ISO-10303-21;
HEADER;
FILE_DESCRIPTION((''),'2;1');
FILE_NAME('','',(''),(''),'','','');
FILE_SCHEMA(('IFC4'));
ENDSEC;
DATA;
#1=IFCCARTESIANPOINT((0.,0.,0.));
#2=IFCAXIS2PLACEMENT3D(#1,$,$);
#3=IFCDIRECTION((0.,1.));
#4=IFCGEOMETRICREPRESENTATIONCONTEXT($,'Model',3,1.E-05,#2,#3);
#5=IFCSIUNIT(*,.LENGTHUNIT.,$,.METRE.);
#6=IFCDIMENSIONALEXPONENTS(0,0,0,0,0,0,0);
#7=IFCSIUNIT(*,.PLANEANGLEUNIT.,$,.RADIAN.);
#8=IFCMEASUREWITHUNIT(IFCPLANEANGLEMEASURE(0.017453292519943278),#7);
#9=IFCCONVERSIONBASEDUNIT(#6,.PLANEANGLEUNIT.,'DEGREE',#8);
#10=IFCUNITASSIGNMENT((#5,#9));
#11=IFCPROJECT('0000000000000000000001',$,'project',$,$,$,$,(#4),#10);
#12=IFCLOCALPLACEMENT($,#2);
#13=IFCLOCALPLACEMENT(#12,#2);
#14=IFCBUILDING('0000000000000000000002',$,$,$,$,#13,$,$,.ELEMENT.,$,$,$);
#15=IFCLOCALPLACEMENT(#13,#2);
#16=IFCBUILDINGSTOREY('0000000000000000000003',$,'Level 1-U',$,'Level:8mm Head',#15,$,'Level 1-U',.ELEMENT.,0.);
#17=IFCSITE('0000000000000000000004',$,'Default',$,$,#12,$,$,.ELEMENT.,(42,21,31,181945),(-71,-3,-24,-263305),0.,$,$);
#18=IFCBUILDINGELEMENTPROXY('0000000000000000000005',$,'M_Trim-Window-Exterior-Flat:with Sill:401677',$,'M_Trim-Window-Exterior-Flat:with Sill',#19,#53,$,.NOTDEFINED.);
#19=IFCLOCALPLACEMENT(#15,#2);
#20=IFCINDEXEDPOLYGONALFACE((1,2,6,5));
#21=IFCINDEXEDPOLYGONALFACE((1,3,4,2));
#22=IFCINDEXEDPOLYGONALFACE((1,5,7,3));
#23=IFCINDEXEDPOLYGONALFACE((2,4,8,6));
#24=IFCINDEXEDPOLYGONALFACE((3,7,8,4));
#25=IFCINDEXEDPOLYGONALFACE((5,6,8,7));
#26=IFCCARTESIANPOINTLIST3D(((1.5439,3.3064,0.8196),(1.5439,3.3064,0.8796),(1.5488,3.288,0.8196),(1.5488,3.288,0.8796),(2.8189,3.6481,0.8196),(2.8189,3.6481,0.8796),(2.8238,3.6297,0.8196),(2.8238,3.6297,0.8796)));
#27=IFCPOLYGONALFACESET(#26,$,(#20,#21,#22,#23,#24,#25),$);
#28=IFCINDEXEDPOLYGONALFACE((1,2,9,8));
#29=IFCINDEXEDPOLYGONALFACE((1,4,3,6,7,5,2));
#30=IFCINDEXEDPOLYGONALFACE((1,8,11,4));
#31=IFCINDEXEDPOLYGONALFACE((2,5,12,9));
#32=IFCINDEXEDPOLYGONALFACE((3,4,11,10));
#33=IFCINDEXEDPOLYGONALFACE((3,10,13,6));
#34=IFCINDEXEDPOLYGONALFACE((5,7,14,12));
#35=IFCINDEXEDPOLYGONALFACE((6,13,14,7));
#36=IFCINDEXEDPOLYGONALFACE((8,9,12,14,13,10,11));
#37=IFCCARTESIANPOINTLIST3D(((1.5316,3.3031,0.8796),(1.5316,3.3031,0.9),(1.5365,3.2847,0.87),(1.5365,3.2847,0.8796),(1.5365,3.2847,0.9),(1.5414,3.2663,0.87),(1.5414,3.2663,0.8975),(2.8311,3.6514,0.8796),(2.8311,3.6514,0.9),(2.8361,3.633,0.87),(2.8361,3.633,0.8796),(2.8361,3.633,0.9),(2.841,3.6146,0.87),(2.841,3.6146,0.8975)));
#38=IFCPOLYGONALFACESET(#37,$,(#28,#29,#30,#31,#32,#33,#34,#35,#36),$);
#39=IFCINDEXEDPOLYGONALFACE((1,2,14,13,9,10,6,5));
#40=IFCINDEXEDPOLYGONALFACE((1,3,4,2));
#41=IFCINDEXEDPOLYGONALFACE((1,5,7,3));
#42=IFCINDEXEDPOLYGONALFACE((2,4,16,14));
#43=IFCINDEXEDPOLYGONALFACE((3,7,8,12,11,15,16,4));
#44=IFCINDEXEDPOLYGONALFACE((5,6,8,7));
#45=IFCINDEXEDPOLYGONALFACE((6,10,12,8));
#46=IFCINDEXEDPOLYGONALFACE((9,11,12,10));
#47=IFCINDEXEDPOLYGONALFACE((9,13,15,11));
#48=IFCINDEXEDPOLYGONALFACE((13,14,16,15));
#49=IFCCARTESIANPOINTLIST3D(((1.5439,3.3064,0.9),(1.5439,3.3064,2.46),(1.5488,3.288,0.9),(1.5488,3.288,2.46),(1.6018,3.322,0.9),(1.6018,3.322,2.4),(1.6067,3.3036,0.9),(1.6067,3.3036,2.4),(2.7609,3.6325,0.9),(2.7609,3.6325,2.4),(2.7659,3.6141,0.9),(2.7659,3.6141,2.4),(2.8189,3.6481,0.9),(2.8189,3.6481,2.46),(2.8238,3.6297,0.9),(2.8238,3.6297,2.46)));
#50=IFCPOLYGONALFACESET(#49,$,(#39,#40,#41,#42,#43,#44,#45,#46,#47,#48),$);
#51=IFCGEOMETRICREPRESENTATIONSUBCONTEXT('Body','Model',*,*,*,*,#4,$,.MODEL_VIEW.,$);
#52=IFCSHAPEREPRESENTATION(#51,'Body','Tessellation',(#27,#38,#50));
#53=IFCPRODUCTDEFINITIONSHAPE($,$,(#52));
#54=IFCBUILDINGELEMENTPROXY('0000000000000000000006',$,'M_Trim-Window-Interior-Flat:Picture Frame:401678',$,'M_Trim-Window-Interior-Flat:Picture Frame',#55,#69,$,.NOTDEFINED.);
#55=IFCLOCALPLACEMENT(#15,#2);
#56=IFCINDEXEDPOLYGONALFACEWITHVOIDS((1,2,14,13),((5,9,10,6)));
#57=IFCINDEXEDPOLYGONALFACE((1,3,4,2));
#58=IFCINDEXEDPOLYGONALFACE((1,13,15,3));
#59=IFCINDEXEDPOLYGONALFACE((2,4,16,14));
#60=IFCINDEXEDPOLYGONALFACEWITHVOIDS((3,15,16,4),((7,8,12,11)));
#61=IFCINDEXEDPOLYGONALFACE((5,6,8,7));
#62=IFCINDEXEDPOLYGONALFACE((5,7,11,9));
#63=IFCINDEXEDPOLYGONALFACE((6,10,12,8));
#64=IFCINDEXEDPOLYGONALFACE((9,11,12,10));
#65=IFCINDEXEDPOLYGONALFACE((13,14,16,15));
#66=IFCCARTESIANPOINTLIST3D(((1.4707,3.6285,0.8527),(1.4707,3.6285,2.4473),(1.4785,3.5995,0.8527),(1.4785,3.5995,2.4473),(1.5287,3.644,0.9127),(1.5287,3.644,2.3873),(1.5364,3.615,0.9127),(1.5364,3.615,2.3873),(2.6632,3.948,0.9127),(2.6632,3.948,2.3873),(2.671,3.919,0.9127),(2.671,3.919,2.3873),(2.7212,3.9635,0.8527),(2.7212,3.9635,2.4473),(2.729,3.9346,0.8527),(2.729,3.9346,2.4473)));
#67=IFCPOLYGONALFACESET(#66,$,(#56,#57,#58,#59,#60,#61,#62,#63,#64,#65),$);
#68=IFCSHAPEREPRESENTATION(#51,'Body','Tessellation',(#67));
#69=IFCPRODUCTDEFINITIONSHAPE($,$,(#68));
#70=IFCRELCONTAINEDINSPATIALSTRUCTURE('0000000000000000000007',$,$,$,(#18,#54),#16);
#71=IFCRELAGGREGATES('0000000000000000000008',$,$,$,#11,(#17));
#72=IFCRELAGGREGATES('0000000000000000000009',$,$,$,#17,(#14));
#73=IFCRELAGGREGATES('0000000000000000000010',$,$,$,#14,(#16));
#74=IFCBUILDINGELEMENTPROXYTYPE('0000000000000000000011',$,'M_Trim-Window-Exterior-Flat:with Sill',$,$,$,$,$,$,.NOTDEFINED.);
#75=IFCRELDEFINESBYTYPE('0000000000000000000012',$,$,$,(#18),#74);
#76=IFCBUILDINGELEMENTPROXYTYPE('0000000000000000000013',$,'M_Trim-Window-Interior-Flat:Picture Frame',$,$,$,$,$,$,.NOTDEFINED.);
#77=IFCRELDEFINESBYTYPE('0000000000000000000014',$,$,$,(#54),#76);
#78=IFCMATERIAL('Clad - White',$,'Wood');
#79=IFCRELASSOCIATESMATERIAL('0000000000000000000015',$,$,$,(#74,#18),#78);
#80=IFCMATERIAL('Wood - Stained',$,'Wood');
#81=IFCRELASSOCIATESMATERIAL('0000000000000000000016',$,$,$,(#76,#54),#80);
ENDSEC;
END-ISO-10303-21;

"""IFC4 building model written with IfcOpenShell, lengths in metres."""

from ifc_helpers import new_model, entity, si_unit, converted_unit, direction, frame, origin, place, context, subcontext, project, spatial, indexed_curve, outline, extrude, source, transform, mapped, material, type_object, type_shapes, element, save


model = new_model("IFC4")

# Units and contexts
model_context = context("Model", 3, precision=1e-05, world=origin(), true_north=direction((0.0, 1.0)))
body_context = subcontext(model_context, "Body", "Model", "MODEL_VIEW")
ifc_project = project(units=[si_unit("LENGTHUNIT", "METRE"), converted_unit("PLANEANGLEUNIT", "DEGREE", entity("IfcPlaneAngleMeasure", 0.017453292519943278), si_unit("PLANEANGLEUNIT", "RADIAN"), dimensions=[0, 0, 0, 0, 0, 0, 0])], contexts=[model_context])

# Site, building, storey
site_placement = place(None, origin())
site = spatial("IfcSite", under=ifc_project, at=site_placement, Name="Default", CompositionType="ELEMENT", RefLatitude=(42, 21, 31, 181945), RefLongitude=(-71, -3, -24, -263305), RefElevation=0.0)
building_placement = place(site_placement, origin())
building = spatial("IfcBuilding", under=site, at=building_placement, CompositionType="ELEMENT")
storey_placement = place(building_placement, origin())
storey = spatial("IfcBuildingStorey", under=building, at=storey_placement, Name="Level 1-U", ObjectType="Level:8mm Head", LongName="Level 1-U", CompositionType="ELEMENT", Elevation=0.0)

# Building element proxies
ifc_material_1 = material(Name="Clad - White", Category="Wood")
ifc_material_2 = material(Name="Wood - Stained", Category="Wood")
building_element_proxy_type_1 = type_object("IfcBuildingElementProxyType", Name="M_Trim-Window-Exterior-Flat:with Sill", PredefinedType="NOTDEFINED", material=ifc_material_1)
shared_shape_1 = source(origin(), body_context, "Body", "SweptSolid", [
    extrude(outline(indexed_curve([(-0.66, -0.03), (0.66, -0.03), (0.66, 0.03), (-0.66, 0.03), (-0.66, -0.03)], self_intersect=False)), frame((0.0, -1.5504, 0.0), z_axis=(0.0, 0.0, 1.0), x_axis=(-1.0, 0.0, 0.0)), (0.0, 0.0, 1.0), 0.019),
    extrude(outline(indexed_curve([(-0.019, -0.0152), (0.0, -0.0152), (0.0, -0.0057), (0.019, -0.0057), (0.019, 0.0148), (0.0, 0.0148), (-0.019, 0.0123), (-0.019, -0.0152)], self_intersect=False)), frame((-0.6727, -1.5148, 0.019), z_axis=(1.0, 0.0, 0.0), x_axis=(0.0, 0.0, -1.0)), (0.0, 0.0, 1.0), 1.3454),
    extrude(outline(indexed_curve([(-0.795, -0.66), (0.765, -0.66), (0.765, -0.6), (-0.735, -0.6), (-0.735, 0.6), (0.765, 0.6), (0.765, 0.66), (-0.795, 0.66), (-0.795, -0.66)], self_intersect=False)), frame((0.0, -0.735, 0.0), z_axis=(0.0, 0.0, 1.0), x_axis=(0.0, -1.0, 0.0)), (0.0, 0.0, 1.0), 0.019),
])
type_shapes(building_element_proxy_type_1, [shared_shape_1])
proxy_1_placement = place(storey_placement, frame((2.1814, 3.4772, 2.4), z_axis=(0.258819, -0.965926, 0.0), x_axis=(0.965926, 0.258819, 0.0)))
element("IfcBuildingElementProxy", 1, at=proxy_1_placement, inside=storey, type_object=building_element_proxy_type_1, material=ifc_material_1, Name="M_Trim-Window-Exterior-Flat:with Sill:401677", ObjectType="M_Trim-Window-Exterior-Flat:with Sill", PredefinedType="NOTDEFINED", context=body_context, shape_type="MappedRepresentation", body=[
    mapped(shared_shape_1, transform((0.0, 0.0, 0.0), scale=1.0)),
])
building_element_proxy_type_2 = type_object("IfcBuildingElementProxyType", Name="M_Trim-Window-Interior-Flat:Picture Frame", PredefinedType="NOTDEFINED", material=ifc_material_2)
shared_shape_2 = source(origin(), body_context, "Body", "SweptSolid", [
    extrude(outline(indexed_curve([(-0.6473, -0.7973), (0.6473, -0.7973), (0.6473, 0.7973), (-0.6473, 0.7973), (-0.6473, -0.7973)], self_intersect=False), holes=[indexed_curve([(-0.5873, -0.7373), (-0.5873, 0.7373), (0.5873, 0.7373), (0.5873, -0.7373), (-0.5873, -0.7373)], self_intersect=False)]), frame((0.0, -0.75, 0.0), z_axis=(0.0, 0.0, 1.0), x_axis=(-1.0, 0.0, 0.0)), (0.0, 0.0, 1.0), 0.03),
])
type_shapes(building_element_proxy_type_2, [shared_shape_2])
proxy_2_placement = place(storey_placement, frame((2.1037, 3.767, 2.4), z_axis=(-0.258819, 0.965926, 0.0), x_axis=(-0.965926, -0.258819, 0.0)))
element("IfcBuildingElementProxy", 2, at=proxy_2_placement, inside=storey, type_object=building_element_proxy_type_2, material=ifc_material_2, Name="M_Trim-Window-Interior-Flat:Picture Frame:401678", ObjectType="M_Trim-Window-Interior-Flat:Picture Frame", PredefinedType="NOTDEFINED", context=body_context, shape_type="MappedRepresentation", body=[
    mapped(shared_shape_2, transform((0.0, 0.0, 0.0), scale=1.0)),
])

save(model, "model.ifc")
